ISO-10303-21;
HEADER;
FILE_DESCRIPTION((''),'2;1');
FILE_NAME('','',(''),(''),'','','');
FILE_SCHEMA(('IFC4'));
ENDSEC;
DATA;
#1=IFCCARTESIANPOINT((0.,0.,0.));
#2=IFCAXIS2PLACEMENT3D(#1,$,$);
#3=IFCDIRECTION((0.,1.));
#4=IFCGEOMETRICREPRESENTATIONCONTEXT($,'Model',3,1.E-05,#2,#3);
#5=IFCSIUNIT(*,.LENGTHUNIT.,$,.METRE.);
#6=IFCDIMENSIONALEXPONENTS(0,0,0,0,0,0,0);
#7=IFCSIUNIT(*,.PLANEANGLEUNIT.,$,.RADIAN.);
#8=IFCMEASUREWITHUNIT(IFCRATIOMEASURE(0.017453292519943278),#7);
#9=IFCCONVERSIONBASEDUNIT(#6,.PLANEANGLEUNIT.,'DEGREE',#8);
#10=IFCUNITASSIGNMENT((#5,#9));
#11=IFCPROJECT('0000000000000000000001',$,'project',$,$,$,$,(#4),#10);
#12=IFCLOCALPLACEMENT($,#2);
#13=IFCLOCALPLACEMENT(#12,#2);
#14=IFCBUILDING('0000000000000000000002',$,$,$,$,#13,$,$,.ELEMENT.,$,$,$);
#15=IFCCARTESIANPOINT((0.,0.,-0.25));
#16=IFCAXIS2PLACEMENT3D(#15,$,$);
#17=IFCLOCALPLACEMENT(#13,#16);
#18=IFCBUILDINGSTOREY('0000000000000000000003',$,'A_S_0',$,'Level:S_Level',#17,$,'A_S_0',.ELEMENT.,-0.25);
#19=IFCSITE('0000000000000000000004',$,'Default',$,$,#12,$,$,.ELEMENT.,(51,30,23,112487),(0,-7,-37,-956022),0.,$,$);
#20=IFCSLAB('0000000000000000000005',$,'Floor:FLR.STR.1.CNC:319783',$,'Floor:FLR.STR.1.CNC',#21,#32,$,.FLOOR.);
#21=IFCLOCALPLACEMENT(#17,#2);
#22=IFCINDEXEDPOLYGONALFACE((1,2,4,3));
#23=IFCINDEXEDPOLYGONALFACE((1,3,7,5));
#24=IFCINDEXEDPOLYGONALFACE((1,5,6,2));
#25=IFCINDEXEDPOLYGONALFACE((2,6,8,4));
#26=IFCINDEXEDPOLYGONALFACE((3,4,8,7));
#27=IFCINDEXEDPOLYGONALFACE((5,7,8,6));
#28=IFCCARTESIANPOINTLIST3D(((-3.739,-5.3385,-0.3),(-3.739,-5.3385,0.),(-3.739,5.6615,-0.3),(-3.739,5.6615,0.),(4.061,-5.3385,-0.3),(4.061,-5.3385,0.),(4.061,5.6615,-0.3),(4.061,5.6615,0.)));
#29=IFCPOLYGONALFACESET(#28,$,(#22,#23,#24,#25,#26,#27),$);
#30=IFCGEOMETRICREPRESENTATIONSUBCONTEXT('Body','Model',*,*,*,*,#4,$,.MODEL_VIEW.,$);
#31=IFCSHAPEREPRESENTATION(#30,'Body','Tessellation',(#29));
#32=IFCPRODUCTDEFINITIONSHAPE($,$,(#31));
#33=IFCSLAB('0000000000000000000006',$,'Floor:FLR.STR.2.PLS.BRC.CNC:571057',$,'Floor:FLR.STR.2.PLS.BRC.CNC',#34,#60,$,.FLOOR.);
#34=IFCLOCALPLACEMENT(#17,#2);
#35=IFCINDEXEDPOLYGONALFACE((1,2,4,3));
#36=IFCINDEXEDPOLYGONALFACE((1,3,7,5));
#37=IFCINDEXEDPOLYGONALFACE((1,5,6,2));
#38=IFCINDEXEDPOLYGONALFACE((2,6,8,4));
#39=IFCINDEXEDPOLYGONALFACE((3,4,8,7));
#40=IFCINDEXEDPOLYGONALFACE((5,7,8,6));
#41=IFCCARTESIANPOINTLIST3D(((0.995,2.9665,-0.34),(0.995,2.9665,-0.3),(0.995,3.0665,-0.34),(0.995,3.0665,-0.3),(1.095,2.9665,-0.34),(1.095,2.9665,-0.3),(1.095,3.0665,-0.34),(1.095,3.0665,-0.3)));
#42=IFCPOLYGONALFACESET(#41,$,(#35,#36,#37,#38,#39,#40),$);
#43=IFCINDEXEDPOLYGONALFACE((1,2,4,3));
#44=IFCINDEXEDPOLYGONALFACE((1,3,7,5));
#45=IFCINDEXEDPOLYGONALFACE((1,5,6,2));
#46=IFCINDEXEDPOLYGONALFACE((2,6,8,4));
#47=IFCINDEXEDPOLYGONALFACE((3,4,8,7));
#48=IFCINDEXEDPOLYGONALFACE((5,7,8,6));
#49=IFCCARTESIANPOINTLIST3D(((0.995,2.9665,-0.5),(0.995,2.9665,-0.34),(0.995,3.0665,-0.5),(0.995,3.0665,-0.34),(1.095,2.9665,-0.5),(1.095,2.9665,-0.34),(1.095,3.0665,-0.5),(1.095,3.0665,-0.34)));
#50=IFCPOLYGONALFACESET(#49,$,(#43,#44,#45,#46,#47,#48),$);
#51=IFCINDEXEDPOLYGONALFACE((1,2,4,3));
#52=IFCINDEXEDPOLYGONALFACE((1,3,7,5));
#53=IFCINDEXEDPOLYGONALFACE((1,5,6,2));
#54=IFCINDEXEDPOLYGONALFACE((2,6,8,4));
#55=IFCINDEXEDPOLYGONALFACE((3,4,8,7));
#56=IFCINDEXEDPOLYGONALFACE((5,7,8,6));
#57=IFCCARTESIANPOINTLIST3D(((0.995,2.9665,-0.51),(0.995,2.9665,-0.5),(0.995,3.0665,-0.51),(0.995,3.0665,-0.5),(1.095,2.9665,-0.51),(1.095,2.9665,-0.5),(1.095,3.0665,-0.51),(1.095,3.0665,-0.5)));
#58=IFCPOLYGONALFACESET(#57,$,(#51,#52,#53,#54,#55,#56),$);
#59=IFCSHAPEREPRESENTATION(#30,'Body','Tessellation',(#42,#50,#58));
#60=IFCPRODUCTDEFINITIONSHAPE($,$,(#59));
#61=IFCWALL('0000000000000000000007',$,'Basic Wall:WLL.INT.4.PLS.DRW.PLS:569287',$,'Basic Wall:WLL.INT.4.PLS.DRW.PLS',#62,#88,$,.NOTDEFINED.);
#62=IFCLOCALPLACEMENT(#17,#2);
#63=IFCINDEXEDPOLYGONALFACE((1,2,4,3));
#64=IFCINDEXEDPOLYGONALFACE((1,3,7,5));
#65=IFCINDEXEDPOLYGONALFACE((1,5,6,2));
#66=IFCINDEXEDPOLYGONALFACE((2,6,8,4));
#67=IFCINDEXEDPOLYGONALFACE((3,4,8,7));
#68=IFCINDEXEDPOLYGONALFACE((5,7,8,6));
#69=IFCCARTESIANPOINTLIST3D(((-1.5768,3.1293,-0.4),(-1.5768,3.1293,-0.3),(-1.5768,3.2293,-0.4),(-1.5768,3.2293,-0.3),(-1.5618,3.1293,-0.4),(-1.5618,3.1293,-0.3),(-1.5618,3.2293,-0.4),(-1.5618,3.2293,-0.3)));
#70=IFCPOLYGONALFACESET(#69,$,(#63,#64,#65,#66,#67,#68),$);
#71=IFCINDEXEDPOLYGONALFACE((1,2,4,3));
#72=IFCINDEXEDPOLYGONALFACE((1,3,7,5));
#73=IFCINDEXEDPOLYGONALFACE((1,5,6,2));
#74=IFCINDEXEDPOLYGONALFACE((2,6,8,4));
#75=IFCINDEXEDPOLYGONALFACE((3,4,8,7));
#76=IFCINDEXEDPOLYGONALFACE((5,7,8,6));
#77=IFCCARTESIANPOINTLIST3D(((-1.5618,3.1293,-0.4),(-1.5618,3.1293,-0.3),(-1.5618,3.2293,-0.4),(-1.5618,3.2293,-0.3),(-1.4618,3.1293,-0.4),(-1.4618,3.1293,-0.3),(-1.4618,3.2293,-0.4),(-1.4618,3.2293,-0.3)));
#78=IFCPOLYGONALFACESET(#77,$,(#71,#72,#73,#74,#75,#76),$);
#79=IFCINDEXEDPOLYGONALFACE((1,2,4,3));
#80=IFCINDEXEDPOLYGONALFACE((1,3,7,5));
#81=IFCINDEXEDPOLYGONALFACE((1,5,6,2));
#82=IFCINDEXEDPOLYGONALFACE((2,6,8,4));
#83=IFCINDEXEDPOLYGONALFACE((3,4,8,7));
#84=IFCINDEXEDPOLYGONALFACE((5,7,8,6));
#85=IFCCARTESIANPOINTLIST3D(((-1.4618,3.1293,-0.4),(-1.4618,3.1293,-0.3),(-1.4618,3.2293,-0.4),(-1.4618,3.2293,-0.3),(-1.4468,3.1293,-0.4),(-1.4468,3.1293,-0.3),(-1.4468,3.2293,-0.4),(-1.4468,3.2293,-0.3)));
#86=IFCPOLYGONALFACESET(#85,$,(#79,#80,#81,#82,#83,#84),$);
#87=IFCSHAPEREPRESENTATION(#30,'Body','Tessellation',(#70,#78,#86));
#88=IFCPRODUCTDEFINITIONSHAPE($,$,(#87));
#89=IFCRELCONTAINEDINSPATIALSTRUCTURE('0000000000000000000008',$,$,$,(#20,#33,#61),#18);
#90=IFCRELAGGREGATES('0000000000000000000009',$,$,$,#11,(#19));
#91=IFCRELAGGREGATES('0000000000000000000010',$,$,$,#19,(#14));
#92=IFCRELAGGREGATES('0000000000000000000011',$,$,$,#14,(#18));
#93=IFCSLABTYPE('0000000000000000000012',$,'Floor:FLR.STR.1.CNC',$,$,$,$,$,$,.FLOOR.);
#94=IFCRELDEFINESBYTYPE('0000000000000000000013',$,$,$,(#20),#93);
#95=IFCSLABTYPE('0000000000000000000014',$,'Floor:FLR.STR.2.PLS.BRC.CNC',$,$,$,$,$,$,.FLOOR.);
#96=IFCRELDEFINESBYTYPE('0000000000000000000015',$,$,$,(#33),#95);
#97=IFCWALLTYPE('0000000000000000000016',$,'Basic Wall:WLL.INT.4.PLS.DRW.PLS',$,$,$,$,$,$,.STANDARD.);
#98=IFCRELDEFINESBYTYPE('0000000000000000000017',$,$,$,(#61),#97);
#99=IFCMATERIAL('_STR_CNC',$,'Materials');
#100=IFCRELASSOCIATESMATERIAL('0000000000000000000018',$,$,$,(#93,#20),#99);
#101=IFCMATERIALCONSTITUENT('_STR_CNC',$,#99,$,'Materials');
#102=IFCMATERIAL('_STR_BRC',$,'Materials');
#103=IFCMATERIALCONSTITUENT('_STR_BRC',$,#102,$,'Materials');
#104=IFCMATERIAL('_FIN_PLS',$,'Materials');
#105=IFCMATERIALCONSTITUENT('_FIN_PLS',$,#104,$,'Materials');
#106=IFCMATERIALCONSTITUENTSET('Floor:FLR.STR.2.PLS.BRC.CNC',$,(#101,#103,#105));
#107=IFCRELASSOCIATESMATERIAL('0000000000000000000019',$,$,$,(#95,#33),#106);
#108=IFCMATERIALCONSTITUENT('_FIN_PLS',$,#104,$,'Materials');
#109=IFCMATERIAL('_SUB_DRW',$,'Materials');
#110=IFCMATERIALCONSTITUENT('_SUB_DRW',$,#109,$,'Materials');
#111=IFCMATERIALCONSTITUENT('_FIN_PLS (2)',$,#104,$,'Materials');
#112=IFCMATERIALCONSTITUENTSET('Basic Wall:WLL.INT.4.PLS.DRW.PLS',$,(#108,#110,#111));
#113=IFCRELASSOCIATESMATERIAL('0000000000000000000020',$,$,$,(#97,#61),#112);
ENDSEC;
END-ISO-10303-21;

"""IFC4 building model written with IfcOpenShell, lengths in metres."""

from ifc_helpers import new_model, entity, si_unit, converted_unit, direction, frame, origin, place, context, subcontext, project, spatial, indexed_curve, outline, extrude, material, constituent, constituent_set, type_object, element, save


model = new_model("IFC4")

# Units and contexts
model_context = context("Model", 3, precision=1e-05, world=origin(), true_north=direction((0.0, 1.0)))
body_context = subcontext(model_context, "Body", "Model", "MODEL_VIEW")
ifc_project = project(units=[si_unit("LENGTHUNIT", "METRE"), converted_unit("PLANEANGLEUNIT", "DEGREE", entity("IfcRatioMeasure", 0.017453292519943278), si_unit("PLANEANGLEUNIT", "RADIAN"), dimensions=[0, 0, 0, 0, 0, 0, 0])], contexts=[model_context])

# Site, building, storey
site_placement = place(None, origin())
site = spatial("IfcSite", under=ifc_project, at=site_placement, Name="Default", CompositionType="ELEMENT", RefLatitude=(51, 30, 23, 112487), RefLongitude=(0, -7, -37, -956022), RefElevation=0.0)
building_placement = place(site_placement, origin())
building = spatial("IfcBuilding", under=site, at=building_placement, CompositionType="ELEMENT")
storey_placement = place(building_placement, frame((0.0, 0.0, -0.25)))
storey = spatial("IfcBuildingStorey", under=building, at=storey_placement, Name="A_S_0", ObjectType="Level:S_Level", LongName="A_S_0", CompositionType="ELEMENT", Elevation=-0.25)

# Slabs
ifc_material_1 = material(Name="_STR_CNC", Category="Materials")
slab_type_1 = type_object("IfcSlabType", Name="Floor:FLR.STR.1.CNC", PredefinedType="FLOOR", material=ifc_material_1)
slab_1_placement = place(storey_placement, origin())
element("IfcSlab", 1, at=slab_1_placement, inside=storey, type_object=slab_type_1, material=ifc_material_1, Name="Floor:FLR.STR.1.CNC:319783", ObjectType="Floor:FLR.STR.1.CNC", PredefinedType="FLOOR", context=body_context, shape_type="SweptSolid", body=[
    extrude(outline(indexed_curve([(-5.5, -3.9), (5.5, -3.9), (5.5, 3.9), (-5.5, 3.9), (-5.5, -3.9)], self_intersect=False)), frame((0.161, 0.1615, 0.0), z_axis=(0.0, 0.0, -1.0), x_axis=(0.0, 1.0, 0.0)), (0.0, 0.0, 1.0), 0.3),
])
ifc_constituent_1 = constituent(ifc_material_1, Name="_STR_CNC", Category="Materials")
ifc_material_2 = material(Name="_STR_BRC", Category="Materials")
ifc_constituent_2 = constituent(ifc_material_2, Name="_STR_BRC", Category="Materials")
ifc_material_3 = material(Name="_FIN_PLS", Category="Materials")
ifc_constituent_3 = constituent(ifc_material_3, Name="_FIN_PLS", Category="Materials")
ifc_constituent_set_1 = constituent_set(constituents=[ifc_constituent_1, ifc_constituent_2, ifc_constituent_3], Name="Floor:FLR.STR.2.PLS.BRC.CNC")
slab_type_2 = type_object("IfcSlabType", Name="Floor:FLR.STR.2.PLS.BRC.CNC", PredefinedType="FLOOR", material=ifc_constituent_set_1)
slab_2_placement = place(storey_placement, origin())
element("IfcSlab", 2, at=slab_2_placement, inside=storey, type_object=slab_type_2, material=ifc_constituent_set_1, Name="Floor:FLR.STR.2.PLS.BRC.CNC:571057", ObjectType="Floor:FLR.STR.2.PLS.BRC.CNC", PredefinedType="FLOOR", context=body_context, shape_type="SweptSolid", body=[
    extrude(outline(indexed_curve([(-0.05, -0.05), (0.05, -0.05), (0.05, 0.05), (-0.05, 0.05), (-0.05, -0.05)], self_intersect=False)), frame((1.045, 3.0165, -0.34), z_axis=(0.0, 0.0, 1.0), x_axis=(-1.0, 0.0, 0.0)), (0.0, 0.0, 1.0), 0.04),
    extrude(outline(indexed_curve([(-0.05, -0.05), (0.05, -0.05), (0.05, 0.05), (-0.05, 0.05), (-0.05, -0.05)], self_intersect=False)), frame((1.045, 3.0165, -0.5), z_axis=(0.0, 0.0, 1.0), x_axis=(-1.0, 0.0, 0.0)), (0.0, 0.0, 1.0), 0.16),
    extrude(outline(indexed_curve([(-0.05, -0.05), (0.05, -0.05), (0.05, 0.05), (-0.05, 0.05), (-0.05, -0.05)], self_intersect=False)), frame((1.045, 3.0165, -0.51), z_axis=(0.0, 0.0, 1.0), x_axis=(-1.0, 0.0, 0.0)), (0.0, 0.0, 1.0), 0.01),
])

# Wall
ifc_constituent_4 = constituent(ifc_material_3, Name="_FIN_PLS", Category="Materials")
ifc_material_4 = material(Name="_SUB_DRW", Category="Materials")
ifc_constituent_5 = constituent(ifc_material_4, Name="_SUB_DRW", Category="Materials")
ifc_constituent_6 = constituent(ifc_material_3, Name="_FIN_PLS (2)", Category="Materials")
ifc_constituent_set_2 = constituent_set(constituents=[ifc_constituent_4, ifc_constituent_5, ifc_constituent_6], Name="Basic Wall:WLL.INT.4.PLS.DRW.PLS")
wall_type_1 = type_object("IfcWallType", Name="Basic Wall:WLL.INT.4.PLS.DRW.PLS", PredefinedType="STANDARD", material=ifc_constituent_set_2)
wall_1_placement = place(storey_placement, frame((-1.5118, 3.2293, -0.4), z_axis=(0.0, 0.0, 1.0), x_axis=(0.0, -1.0, 0.0)))
element("IfcWall", 3, at=wall_1_placement, inside=storey, type_object=wall_type_1, material=ifc_constituent_set_2, Name="Basic Wall:WLL.INT.4.PLS.DRW.PLS:569287", ObjectType="Basic Wall:WLL.INT.4.PLS.DRW.PLS", PredefinedType="NOTDEFINED", context=body_context, shape_type="SweptSolid", body=[
    extrude(outline(indexed_curve([(-0.0075, -0.05), (0.0075, -0.05), (0.0075, 0.05), (-0.0075, 0.05), (-0.0075, -0.05)], self_intersect=False)), frame((0.05, -0.0575, 0.0), z_axis=(0.0, 0.0, 1.0), x_axis=(0.0, 1.0, 0.0)), (0.0, 0.0, 1.0), 0.1),
    extrude(outline(indexed_curve([(-0.05, -0.05), (0.05, -0.05), (0.05, 0.05), (-0.05, 0.05), (-0.05, -0.05)], self_intersect=False)), frame((0.05, 0.0, 0.0)), (0.0, 0.0, 1.0), 0.1),
    extrude(outline(indexed_curve([(-0.0075, -0.05), (0.0075, -0.05), (0.0075, 0.05), (-0.0075, 0.05), (-0.0075, -0.05)], self_intersect=False)), frame((0.05, 0.0575, 0.0), z_axis=(0.0, 0.0, 1.0), x_axis=(0.0, -1.0, 0.0)), (0.0, 0.0, 1.0), 0.1),
])

save(model, "model.ifc")
